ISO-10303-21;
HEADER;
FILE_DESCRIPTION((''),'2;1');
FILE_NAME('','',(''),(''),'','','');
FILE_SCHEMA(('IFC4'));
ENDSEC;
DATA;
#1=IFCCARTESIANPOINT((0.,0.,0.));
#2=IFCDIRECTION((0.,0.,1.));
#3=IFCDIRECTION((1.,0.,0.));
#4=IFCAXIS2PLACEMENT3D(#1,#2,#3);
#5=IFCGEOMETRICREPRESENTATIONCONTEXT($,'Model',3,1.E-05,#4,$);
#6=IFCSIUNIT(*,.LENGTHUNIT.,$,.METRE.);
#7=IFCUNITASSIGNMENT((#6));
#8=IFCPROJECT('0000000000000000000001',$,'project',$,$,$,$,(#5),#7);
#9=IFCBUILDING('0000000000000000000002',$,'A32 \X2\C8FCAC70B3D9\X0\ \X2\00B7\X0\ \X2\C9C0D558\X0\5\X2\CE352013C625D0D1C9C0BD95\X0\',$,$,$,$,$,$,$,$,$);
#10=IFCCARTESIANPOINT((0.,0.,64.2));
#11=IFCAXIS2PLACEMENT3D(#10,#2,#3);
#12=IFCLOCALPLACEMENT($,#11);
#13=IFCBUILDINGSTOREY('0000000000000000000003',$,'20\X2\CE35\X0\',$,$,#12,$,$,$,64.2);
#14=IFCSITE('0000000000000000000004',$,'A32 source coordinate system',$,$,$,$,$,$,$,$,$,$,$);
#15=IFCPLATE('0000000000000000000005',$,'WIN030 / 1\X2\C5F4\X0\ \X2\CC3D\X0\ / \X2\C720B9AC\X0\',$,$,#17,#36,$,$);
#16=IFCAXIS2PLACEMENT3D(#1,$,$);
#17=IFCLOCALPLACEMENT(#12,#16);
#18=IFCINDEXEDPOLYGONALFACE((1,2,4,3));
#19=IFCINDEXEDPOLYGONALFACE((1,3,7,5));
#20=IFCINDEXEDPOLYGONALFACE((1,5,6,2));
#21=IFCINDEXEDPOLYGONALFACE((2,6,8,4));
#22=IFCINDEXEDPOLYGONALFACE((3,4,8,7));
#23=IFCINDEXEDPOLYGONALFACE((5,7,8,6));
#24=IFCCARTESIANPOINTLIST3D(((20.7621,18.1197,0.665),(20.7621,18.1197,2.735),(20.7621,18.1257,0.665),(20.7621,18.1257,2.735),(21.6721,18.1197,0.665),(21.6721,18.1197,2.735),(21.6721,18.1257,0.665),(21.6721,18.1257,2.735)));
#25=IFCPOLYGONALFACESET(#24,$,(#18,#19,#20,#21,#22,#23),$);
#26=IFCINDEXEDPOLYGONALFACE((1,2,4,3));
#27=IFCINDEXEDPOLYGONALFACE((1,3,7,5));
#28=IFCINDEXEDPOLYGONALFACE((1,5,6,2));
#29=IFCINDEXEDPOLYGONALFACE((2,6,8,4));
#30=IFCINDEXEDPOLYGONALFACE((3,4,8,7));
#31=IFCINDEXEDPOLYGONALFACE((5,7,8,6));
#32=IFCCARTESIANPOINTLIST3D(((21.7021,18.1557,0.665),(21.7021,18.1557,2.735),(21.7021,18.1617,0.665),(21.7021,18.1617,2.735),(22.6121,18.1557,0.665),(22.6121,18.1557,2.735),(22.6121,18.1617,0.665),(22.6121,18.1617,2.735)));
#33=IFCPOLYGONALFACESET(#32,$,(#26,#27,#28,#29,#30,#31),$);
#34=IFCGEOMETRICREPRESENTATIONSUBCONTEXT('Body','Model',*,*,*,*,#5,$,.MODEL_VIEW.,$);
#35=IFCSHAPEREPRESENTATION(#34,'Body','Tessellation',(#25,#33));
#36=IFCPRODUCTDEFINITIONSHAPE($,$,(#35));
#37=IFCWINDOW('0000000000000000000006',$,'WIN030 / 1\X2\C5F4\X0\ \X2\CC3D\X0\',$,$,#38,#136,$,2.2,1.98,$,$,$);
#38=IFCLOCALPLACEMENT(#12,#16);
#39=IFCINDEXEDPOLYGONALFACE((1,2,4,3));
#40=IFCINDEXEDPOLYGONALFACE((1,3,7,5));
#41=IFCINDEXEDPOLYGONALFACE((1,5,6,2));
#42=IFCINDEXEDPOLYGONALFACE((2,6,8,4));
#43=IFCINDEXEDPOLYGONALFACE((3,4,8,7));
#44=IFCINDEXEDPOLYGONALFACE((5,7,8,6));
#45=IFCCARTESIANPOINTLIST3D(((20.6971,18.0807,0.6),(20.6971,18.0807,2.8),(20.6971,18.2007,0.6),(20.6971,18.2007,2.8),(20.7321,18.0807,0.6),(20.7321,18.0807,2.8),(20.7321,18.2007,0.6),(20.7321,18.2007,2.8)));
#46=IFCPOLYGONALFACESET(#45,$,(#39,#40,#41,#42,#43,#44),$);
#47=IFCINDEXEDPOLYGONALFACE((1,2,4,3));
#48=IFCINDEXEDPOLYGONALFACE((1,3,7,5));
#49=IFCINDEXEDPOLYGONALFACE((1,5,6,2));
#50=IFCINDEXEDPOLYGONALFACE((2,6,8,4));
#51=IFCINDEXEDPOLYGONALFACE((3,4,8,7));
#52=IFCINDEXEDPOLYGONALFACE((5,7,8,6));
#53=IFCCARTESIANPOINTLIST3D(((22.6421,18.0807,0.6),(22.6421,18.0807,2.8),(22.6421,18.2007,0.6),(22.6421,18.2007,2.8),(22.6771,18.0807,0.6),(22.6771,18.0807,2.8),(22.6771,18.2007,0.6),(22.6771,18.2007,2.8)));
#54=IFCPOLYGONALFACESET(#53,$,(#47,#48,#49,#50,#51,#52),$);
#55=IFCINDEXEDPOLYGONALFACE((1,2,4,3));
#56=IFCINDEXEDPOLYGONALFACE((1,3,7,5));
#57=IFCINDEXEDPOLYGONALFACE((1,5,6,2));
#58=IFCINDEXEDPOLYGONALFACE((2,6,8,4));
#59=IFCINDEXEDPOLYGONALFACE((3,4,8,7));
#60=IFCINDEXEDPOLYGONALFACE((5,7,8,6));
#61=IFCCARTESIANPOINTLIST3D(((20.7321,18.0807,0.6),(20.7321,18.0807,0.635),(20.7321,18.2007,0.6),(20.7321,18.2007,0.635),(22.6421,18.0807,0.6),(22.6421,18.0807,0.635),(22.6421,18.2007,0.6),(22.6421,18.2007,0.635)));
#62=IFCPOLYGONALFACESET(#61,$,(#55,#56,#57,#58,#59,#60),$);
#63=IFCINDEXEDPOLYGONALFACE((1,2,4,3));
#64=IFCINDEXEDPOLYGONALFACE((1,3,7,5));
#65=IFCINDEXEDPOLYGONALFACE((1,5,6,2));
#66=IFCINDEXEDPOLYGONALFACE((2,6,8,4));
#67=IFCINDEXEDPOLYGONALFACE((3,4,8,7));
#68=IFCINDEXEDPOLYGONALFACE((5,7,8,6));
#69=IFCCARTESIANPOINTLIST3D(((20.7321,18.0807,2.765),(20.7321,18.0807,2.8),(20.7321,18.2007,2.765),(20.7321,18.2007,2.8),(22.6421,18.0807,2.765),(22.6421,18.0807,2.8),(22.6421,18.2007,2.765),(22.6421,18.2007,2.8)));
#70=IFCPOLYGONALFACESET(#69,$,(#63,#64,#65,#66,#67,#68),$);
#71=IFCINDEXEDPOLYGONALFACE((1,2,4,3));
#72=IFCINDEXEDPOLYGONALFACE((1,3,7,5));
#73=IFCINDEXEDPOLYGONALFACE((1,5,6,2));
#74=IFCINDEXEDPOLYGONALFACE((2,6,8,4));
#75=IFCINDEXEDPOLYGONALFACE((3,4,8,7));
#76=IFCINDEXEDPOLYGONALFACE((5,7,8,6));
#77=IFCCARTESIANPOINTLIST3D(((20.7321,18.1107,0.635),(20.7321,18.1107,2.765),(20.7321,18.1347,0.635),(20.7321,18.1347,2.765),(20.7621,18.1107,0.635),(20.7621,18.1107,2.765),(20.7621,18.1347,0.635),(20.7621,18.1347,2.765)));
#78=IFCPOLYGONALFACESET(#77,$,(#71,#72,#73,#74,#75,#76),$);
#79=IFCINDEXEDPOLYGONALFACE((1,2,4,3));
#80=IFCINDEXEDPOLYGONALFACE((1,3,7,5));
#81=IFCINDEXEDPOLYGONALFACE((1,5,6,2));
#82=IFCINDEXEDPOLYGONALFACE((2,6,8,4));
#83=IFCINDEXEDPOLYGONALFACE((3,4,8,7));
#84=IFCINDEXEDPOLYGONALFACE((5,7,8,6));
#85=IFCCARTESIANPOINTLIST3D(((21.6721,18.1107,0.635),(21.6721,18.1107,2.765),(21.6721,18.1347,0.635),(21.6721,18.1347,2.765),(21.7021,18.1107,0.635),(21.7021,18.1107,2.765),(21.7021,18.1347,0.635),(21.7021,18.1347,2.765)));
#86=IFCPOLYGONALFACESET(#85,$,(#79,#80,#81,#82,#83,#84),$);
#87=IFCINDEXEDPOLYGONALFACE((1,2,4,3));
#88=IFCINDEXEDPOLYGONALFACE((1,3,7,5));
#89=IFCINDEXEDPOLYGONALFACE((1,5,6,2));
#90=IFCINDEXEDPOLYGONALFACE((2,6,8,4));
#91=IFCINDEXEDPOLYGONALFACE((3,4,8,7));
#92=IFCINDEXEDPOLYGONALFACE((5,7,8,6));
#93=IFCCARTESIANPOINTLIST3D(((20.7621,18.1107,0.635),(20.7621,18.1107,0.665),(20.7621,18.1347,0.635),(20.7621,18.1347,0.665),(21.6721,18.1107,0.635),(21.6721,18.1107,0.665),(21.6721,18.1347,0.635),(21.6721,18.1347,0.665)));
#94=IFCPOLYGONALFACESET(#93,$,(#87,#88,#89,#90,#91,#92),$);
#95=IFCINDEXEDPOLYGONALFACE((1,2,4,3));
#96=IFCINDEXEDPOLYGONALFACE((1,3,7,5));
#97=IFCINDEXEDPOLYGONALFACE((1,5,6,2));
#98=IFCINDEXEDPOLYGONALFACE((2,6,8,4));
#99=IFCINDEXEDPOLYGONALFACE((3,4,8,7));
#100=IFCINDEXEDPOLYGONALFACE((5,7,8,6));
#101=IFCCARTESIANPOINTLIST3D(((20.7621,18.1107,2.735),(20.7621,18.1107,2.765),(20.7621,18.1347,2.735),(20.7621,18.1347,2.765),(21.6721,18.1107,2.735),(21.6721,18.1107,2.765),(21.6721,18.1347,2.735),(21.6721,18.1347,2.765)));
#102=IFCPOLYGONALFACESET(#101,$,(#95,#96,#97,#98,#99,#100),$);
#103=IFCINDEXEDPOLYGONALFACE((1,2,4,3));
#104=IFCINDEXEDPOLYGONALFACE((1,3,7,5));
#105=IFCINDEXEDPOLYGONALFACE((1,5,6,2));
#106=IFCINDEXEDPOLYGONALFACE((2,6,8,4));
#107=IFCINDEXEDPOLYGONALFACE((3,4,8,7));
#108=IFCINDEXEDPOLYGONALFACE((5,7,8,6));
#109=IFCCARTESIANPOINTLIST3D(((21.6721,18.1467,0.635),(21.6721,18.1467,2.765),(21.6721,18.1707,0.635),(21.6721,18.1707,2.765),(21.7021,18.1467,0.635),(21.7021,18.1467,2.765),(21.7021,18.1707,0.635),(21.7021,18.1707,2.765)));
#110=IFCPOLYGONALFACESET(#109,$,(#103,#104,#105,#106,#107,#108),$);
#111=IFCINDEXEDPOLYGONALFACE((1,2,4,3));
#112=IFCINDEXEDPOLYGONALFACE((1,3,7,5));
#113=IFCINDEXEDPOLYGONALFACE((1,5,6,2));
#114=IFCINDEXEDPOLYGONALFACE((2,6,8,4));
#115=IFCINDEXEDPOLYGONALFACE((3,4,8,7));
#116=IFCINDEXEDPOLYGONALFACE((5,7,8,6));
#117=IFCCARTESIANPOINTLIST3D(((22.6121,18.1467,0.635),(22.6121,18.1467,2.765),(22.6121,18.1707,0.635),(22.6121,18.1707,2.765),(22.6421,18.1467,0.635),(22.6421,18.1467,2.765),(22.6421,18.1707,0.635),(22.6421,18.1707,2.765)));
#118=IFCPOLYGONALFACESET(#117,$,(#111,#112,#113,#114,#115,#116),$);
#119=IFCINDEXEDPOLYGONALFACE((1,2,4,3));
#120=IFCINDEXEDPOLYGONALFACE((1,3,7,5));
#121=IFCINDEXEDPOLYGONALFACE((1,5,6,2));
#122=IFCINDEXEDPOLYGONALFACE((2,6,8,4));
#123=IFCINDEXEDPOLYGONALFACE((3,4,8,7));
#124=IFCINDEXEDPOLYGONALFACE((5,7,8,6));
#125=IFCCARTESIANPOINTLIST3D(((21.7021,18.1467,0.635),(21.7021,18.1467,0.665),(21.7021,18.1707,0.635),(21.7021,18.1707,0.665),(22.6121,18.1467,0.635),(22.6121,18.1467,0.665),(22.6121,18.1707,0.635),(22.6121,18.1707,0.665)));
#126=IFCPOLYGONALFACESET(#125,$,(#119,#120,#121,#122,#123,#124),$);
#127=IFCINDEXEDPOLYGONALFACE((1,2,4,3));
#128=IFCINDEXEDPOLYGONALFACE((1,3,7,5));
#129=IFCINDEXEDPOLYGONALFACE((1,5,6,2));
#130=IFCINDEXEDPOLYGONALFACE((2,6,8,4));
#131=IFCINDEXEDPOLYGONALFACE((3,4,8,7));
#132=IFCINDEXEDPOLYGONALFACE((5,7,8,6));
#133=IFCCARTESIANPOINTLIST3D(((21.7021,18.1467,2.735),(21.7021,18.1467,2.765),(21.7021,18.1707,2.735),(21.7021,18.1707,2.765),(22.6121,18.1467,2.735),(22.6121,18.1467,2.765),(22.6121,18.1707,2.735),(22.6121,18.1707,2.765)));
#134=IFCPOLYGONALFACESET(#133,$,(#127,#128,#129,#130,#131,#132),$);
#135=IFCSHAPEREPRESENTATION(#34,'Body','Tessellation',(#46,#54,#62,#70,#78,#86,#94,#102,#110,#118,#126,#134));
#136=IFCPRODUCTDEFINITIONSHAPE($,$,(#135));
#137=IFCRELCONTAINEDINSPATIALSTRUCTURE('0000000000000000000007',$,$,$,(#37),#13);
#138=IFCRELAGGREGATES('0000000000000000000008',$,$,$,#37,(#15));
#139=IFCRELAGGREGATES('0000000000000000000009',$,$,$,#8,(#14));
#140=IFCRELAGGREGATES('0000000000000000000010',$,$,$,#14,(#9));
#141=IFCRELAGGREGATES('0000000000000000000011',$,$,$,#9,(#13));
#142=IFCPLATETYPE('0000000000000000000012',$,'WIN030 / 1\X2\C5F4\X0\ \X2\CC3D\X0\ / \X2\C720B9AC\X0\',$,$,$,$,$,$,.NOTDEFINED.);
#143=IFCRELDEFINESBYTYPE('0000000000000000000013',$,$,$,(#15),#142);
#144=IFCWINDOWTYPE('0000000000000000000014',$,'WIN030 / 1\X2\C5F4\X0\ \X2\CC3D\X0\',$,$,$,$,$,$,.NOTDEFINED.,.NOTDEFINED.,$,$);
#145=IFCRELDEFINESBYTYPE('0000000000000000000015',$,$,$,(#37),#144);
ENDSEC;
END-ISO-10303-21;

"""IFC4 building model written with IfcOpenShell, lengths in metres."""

from ifc_helpers import new_model, si_unit, frame, origin, origin_with_axes, place, context, subcontext, project, spatial, polyline, outline, extrude, source, transform, mapped, type_object, type_shapes, element, aggregate, save


model = new_model("IFC4")

# Units and contexts
model_context = context("Model", 3, precision=1e-05, world=origin_with_axes())
body_context = subcontext(model_context, "Body", "Model", "MODEL_VIEW")
ifc_project = project(units=[si_unit("LENGTHUNIT", "METRE")], contexts=[model_context])

# Plate
storey_placement = place(None, frame((0.0, 0.0, 64.2), z_axis=(0.0, 0.0, 1.0), x_axis=(1.0, 0.0, 0.0)))
plate_type_1 = type_object("IfcPlateType", Name="WIN030 / 1열 창 / 유리", PredefinedType="NOTDEFINED")
shared_shape_1 = source(origin(), body_context, "Body", "SweptSolid", [
    extrude(outline(polyline([(20.7621, 18.1197), (20.7621, 18.1257), (21.6721, 18.1257), (21.6721, 18.1197), (20.7621, 18.1197)])), frame((0.0, 0.0, 0.665)), (0.0, 0.0, 1.0), 2.07),
    extrude(outline(polyline([(21.7021, 18.1557), (21.7021, 18.1617), (22.6121, 18.1617), (22.6121, 18.1557), (21.7021, 18.1557)])), frame((0.0, 0.0, 0.665)), (0.0, 0.0, 1.0), 2.07),
])
type_shapes(plate_type_1, [shared_shape_1])
window_1_placement = place(storey_placement, origin_with_axes())
plate_1_placement = place(window_1_placement, origin_with_axes())
plate_1 = element("IfcPlate", 1, at=plate_1_placement, type_object=plate_type_1, Name="WIN030 / 1열 창 / 유리", context=body_context, shape_type="MappedRepresentation", body=[
    mapped(shared_shape_1, transform((0.0, 0.0, 0.0), scale=1.0)),
])

# Site, building, storey
site = spatial("IfcSite", under=ifc_project, Name="A32 source coordinate system")
building = spatial("IfcBuilding", under=site, Name="A32 주거동 · 지하5층–옥탑지붕")
storey = spatial("IfcBuildingStorey", under=building, at=storey_placement, Name="20층", Elevation=64.2)

# Window
window_type_1 = type_object("IfcWindowType", Name="WIN030 / 1열 창", PartitioningType="NOTDEFINED", PredefinedType="NOTDEFINED")
shared_shape_2 = source(origin(), body_context, "Body", "SweptSolid", [
    extrude(outline(polyline([(20.6971, 18.0807), (20.6971, 18.2007), (20.7321, 18.2007), (20.7321, 18.0807), (20.6971, 18.0807)])), frame((0.0, 0.0, 0.6)), (0.0, 0.0, 1.0), 2.2),
    extrude(outline(polyline([(22.6421, 18.0807), (22.6421, 18.2007), (22.6771, 18.2007), (22.6771, 18.0807), (22.6421, 18.0807)])), frame((0.0, 0.0, 0.6)), (0.0, 0.0, 1.0), 2.2),
    extrude(outline(polyline([(20.7321, 18.0807), (20.7321, 18.2007), (22.6421, 18.2007), (22.6421, 18.0807), (20.7321, 18.0807)])), frame((0.0, 0.0, 0.6)), (0.0, 0.0, 1.0), 0.035),
    extrude(outline(polyline([(20.7321, 18.0807), (20.7321, 18.2007), (22.6421, 18.2007), (22.6421, 18.0807), (20.7321, 18.0807)])), frame((0.0, 0.0, 2.765)), (0.0, 0.0, 1.0), 0.035),
    extrude(outline(polyline([(20.7321, 18.1107), (20.7321, 18.1347), (20.7621, 18.1347), (20.7621, 18.1107), (20.7321, 18.1107)])), frame((0.0, 0.0, 0.635)), (0.0, 0.0, 1.0), 2.13),
    extrude(outline(polyline([(21.6721, 18.1107), (21.6721, 18.1347), (21.7021, 18.1347), (21.7021, 18.1107), (21.6721, 18.1107)])), frame((0.0, 0.0, 0.635)), (0.0, 0.0, 1.0), 2.13),
    extrude(outline(polyline([(20.7621, 18.1107), (20.7621, 18.1347), (21.6721, 18.1347), (21.6721, 18.1107), (20.7621, 18.1107)])), frame((0.0, 0.0, 0.635)), (0.0, 0.0, 1.0), 0.03),
    extrude(outline(polyline([(20.7621, 18.1107), (20.7621, 18.1347), (21.6721, 18.1347), (21.6721, 18.1107), (20.7621, 18.1107)])), frame((0.0, 0.0, 2.735)), (0.0, 0.0, 1.0), 0.03),
    extrude(outline(polyline([(21.6721, 18.1467), (21.6721, 18.1707), (21.7021, 18.1707), (21.7021, 18.1467), (21.6721, 18.1467)])), frame((0.0, 0.0, 0.635)), (0.0, 0.0, 1.0), 2.13),
    extrude(outline(polyline([(22.6121, 18.1467), (22.6121, 18.1707), (22.6421, 18.1707), (22.6421, 18.1467), (22.6121, 18.1467)])), frame((0.0, 0.0, 0.635)), (0.0, 0.0, 1.0), 2.13),
    extrude(outline(polyline([(21.7021, 18.1467), (21.7021, 18.1707), (22.6121, 18.1707), (22.6121, 18.1467), (21.7021, 18.1467)])), frame((0.0, 0.0, 0.635)), (0.0, 0.0, 1.0), 0.03),
    extrude(outline(polyline([(21.7021, 18.1467), (21.7021, 18.1707), (22.6121, 18.1707), (22.6121, 18.1467), (21.7021, 18.1467)])), frame((0.0, 0.0, 2.735)), (0.0, 0.0, 1.0), 0.03),
])
type_shapes(window_type_1, [shared_shape_2])
window_1 = element("IfcWindow", 2, at=window_1_placement, inside=storey, type_object=window_type_1, Name="WIN030 / 1열 창", OverallHeight=2.2, OverallWidth=1.98, context=body_context, shape_type="MappedRepresentation", body=[
    mapped(shared_shape_2, transform((0.0, 0.0, 0.0), scale=1.0)),
])
aggregate(window_1, [plate_1])

save(model, "model.ifc")
